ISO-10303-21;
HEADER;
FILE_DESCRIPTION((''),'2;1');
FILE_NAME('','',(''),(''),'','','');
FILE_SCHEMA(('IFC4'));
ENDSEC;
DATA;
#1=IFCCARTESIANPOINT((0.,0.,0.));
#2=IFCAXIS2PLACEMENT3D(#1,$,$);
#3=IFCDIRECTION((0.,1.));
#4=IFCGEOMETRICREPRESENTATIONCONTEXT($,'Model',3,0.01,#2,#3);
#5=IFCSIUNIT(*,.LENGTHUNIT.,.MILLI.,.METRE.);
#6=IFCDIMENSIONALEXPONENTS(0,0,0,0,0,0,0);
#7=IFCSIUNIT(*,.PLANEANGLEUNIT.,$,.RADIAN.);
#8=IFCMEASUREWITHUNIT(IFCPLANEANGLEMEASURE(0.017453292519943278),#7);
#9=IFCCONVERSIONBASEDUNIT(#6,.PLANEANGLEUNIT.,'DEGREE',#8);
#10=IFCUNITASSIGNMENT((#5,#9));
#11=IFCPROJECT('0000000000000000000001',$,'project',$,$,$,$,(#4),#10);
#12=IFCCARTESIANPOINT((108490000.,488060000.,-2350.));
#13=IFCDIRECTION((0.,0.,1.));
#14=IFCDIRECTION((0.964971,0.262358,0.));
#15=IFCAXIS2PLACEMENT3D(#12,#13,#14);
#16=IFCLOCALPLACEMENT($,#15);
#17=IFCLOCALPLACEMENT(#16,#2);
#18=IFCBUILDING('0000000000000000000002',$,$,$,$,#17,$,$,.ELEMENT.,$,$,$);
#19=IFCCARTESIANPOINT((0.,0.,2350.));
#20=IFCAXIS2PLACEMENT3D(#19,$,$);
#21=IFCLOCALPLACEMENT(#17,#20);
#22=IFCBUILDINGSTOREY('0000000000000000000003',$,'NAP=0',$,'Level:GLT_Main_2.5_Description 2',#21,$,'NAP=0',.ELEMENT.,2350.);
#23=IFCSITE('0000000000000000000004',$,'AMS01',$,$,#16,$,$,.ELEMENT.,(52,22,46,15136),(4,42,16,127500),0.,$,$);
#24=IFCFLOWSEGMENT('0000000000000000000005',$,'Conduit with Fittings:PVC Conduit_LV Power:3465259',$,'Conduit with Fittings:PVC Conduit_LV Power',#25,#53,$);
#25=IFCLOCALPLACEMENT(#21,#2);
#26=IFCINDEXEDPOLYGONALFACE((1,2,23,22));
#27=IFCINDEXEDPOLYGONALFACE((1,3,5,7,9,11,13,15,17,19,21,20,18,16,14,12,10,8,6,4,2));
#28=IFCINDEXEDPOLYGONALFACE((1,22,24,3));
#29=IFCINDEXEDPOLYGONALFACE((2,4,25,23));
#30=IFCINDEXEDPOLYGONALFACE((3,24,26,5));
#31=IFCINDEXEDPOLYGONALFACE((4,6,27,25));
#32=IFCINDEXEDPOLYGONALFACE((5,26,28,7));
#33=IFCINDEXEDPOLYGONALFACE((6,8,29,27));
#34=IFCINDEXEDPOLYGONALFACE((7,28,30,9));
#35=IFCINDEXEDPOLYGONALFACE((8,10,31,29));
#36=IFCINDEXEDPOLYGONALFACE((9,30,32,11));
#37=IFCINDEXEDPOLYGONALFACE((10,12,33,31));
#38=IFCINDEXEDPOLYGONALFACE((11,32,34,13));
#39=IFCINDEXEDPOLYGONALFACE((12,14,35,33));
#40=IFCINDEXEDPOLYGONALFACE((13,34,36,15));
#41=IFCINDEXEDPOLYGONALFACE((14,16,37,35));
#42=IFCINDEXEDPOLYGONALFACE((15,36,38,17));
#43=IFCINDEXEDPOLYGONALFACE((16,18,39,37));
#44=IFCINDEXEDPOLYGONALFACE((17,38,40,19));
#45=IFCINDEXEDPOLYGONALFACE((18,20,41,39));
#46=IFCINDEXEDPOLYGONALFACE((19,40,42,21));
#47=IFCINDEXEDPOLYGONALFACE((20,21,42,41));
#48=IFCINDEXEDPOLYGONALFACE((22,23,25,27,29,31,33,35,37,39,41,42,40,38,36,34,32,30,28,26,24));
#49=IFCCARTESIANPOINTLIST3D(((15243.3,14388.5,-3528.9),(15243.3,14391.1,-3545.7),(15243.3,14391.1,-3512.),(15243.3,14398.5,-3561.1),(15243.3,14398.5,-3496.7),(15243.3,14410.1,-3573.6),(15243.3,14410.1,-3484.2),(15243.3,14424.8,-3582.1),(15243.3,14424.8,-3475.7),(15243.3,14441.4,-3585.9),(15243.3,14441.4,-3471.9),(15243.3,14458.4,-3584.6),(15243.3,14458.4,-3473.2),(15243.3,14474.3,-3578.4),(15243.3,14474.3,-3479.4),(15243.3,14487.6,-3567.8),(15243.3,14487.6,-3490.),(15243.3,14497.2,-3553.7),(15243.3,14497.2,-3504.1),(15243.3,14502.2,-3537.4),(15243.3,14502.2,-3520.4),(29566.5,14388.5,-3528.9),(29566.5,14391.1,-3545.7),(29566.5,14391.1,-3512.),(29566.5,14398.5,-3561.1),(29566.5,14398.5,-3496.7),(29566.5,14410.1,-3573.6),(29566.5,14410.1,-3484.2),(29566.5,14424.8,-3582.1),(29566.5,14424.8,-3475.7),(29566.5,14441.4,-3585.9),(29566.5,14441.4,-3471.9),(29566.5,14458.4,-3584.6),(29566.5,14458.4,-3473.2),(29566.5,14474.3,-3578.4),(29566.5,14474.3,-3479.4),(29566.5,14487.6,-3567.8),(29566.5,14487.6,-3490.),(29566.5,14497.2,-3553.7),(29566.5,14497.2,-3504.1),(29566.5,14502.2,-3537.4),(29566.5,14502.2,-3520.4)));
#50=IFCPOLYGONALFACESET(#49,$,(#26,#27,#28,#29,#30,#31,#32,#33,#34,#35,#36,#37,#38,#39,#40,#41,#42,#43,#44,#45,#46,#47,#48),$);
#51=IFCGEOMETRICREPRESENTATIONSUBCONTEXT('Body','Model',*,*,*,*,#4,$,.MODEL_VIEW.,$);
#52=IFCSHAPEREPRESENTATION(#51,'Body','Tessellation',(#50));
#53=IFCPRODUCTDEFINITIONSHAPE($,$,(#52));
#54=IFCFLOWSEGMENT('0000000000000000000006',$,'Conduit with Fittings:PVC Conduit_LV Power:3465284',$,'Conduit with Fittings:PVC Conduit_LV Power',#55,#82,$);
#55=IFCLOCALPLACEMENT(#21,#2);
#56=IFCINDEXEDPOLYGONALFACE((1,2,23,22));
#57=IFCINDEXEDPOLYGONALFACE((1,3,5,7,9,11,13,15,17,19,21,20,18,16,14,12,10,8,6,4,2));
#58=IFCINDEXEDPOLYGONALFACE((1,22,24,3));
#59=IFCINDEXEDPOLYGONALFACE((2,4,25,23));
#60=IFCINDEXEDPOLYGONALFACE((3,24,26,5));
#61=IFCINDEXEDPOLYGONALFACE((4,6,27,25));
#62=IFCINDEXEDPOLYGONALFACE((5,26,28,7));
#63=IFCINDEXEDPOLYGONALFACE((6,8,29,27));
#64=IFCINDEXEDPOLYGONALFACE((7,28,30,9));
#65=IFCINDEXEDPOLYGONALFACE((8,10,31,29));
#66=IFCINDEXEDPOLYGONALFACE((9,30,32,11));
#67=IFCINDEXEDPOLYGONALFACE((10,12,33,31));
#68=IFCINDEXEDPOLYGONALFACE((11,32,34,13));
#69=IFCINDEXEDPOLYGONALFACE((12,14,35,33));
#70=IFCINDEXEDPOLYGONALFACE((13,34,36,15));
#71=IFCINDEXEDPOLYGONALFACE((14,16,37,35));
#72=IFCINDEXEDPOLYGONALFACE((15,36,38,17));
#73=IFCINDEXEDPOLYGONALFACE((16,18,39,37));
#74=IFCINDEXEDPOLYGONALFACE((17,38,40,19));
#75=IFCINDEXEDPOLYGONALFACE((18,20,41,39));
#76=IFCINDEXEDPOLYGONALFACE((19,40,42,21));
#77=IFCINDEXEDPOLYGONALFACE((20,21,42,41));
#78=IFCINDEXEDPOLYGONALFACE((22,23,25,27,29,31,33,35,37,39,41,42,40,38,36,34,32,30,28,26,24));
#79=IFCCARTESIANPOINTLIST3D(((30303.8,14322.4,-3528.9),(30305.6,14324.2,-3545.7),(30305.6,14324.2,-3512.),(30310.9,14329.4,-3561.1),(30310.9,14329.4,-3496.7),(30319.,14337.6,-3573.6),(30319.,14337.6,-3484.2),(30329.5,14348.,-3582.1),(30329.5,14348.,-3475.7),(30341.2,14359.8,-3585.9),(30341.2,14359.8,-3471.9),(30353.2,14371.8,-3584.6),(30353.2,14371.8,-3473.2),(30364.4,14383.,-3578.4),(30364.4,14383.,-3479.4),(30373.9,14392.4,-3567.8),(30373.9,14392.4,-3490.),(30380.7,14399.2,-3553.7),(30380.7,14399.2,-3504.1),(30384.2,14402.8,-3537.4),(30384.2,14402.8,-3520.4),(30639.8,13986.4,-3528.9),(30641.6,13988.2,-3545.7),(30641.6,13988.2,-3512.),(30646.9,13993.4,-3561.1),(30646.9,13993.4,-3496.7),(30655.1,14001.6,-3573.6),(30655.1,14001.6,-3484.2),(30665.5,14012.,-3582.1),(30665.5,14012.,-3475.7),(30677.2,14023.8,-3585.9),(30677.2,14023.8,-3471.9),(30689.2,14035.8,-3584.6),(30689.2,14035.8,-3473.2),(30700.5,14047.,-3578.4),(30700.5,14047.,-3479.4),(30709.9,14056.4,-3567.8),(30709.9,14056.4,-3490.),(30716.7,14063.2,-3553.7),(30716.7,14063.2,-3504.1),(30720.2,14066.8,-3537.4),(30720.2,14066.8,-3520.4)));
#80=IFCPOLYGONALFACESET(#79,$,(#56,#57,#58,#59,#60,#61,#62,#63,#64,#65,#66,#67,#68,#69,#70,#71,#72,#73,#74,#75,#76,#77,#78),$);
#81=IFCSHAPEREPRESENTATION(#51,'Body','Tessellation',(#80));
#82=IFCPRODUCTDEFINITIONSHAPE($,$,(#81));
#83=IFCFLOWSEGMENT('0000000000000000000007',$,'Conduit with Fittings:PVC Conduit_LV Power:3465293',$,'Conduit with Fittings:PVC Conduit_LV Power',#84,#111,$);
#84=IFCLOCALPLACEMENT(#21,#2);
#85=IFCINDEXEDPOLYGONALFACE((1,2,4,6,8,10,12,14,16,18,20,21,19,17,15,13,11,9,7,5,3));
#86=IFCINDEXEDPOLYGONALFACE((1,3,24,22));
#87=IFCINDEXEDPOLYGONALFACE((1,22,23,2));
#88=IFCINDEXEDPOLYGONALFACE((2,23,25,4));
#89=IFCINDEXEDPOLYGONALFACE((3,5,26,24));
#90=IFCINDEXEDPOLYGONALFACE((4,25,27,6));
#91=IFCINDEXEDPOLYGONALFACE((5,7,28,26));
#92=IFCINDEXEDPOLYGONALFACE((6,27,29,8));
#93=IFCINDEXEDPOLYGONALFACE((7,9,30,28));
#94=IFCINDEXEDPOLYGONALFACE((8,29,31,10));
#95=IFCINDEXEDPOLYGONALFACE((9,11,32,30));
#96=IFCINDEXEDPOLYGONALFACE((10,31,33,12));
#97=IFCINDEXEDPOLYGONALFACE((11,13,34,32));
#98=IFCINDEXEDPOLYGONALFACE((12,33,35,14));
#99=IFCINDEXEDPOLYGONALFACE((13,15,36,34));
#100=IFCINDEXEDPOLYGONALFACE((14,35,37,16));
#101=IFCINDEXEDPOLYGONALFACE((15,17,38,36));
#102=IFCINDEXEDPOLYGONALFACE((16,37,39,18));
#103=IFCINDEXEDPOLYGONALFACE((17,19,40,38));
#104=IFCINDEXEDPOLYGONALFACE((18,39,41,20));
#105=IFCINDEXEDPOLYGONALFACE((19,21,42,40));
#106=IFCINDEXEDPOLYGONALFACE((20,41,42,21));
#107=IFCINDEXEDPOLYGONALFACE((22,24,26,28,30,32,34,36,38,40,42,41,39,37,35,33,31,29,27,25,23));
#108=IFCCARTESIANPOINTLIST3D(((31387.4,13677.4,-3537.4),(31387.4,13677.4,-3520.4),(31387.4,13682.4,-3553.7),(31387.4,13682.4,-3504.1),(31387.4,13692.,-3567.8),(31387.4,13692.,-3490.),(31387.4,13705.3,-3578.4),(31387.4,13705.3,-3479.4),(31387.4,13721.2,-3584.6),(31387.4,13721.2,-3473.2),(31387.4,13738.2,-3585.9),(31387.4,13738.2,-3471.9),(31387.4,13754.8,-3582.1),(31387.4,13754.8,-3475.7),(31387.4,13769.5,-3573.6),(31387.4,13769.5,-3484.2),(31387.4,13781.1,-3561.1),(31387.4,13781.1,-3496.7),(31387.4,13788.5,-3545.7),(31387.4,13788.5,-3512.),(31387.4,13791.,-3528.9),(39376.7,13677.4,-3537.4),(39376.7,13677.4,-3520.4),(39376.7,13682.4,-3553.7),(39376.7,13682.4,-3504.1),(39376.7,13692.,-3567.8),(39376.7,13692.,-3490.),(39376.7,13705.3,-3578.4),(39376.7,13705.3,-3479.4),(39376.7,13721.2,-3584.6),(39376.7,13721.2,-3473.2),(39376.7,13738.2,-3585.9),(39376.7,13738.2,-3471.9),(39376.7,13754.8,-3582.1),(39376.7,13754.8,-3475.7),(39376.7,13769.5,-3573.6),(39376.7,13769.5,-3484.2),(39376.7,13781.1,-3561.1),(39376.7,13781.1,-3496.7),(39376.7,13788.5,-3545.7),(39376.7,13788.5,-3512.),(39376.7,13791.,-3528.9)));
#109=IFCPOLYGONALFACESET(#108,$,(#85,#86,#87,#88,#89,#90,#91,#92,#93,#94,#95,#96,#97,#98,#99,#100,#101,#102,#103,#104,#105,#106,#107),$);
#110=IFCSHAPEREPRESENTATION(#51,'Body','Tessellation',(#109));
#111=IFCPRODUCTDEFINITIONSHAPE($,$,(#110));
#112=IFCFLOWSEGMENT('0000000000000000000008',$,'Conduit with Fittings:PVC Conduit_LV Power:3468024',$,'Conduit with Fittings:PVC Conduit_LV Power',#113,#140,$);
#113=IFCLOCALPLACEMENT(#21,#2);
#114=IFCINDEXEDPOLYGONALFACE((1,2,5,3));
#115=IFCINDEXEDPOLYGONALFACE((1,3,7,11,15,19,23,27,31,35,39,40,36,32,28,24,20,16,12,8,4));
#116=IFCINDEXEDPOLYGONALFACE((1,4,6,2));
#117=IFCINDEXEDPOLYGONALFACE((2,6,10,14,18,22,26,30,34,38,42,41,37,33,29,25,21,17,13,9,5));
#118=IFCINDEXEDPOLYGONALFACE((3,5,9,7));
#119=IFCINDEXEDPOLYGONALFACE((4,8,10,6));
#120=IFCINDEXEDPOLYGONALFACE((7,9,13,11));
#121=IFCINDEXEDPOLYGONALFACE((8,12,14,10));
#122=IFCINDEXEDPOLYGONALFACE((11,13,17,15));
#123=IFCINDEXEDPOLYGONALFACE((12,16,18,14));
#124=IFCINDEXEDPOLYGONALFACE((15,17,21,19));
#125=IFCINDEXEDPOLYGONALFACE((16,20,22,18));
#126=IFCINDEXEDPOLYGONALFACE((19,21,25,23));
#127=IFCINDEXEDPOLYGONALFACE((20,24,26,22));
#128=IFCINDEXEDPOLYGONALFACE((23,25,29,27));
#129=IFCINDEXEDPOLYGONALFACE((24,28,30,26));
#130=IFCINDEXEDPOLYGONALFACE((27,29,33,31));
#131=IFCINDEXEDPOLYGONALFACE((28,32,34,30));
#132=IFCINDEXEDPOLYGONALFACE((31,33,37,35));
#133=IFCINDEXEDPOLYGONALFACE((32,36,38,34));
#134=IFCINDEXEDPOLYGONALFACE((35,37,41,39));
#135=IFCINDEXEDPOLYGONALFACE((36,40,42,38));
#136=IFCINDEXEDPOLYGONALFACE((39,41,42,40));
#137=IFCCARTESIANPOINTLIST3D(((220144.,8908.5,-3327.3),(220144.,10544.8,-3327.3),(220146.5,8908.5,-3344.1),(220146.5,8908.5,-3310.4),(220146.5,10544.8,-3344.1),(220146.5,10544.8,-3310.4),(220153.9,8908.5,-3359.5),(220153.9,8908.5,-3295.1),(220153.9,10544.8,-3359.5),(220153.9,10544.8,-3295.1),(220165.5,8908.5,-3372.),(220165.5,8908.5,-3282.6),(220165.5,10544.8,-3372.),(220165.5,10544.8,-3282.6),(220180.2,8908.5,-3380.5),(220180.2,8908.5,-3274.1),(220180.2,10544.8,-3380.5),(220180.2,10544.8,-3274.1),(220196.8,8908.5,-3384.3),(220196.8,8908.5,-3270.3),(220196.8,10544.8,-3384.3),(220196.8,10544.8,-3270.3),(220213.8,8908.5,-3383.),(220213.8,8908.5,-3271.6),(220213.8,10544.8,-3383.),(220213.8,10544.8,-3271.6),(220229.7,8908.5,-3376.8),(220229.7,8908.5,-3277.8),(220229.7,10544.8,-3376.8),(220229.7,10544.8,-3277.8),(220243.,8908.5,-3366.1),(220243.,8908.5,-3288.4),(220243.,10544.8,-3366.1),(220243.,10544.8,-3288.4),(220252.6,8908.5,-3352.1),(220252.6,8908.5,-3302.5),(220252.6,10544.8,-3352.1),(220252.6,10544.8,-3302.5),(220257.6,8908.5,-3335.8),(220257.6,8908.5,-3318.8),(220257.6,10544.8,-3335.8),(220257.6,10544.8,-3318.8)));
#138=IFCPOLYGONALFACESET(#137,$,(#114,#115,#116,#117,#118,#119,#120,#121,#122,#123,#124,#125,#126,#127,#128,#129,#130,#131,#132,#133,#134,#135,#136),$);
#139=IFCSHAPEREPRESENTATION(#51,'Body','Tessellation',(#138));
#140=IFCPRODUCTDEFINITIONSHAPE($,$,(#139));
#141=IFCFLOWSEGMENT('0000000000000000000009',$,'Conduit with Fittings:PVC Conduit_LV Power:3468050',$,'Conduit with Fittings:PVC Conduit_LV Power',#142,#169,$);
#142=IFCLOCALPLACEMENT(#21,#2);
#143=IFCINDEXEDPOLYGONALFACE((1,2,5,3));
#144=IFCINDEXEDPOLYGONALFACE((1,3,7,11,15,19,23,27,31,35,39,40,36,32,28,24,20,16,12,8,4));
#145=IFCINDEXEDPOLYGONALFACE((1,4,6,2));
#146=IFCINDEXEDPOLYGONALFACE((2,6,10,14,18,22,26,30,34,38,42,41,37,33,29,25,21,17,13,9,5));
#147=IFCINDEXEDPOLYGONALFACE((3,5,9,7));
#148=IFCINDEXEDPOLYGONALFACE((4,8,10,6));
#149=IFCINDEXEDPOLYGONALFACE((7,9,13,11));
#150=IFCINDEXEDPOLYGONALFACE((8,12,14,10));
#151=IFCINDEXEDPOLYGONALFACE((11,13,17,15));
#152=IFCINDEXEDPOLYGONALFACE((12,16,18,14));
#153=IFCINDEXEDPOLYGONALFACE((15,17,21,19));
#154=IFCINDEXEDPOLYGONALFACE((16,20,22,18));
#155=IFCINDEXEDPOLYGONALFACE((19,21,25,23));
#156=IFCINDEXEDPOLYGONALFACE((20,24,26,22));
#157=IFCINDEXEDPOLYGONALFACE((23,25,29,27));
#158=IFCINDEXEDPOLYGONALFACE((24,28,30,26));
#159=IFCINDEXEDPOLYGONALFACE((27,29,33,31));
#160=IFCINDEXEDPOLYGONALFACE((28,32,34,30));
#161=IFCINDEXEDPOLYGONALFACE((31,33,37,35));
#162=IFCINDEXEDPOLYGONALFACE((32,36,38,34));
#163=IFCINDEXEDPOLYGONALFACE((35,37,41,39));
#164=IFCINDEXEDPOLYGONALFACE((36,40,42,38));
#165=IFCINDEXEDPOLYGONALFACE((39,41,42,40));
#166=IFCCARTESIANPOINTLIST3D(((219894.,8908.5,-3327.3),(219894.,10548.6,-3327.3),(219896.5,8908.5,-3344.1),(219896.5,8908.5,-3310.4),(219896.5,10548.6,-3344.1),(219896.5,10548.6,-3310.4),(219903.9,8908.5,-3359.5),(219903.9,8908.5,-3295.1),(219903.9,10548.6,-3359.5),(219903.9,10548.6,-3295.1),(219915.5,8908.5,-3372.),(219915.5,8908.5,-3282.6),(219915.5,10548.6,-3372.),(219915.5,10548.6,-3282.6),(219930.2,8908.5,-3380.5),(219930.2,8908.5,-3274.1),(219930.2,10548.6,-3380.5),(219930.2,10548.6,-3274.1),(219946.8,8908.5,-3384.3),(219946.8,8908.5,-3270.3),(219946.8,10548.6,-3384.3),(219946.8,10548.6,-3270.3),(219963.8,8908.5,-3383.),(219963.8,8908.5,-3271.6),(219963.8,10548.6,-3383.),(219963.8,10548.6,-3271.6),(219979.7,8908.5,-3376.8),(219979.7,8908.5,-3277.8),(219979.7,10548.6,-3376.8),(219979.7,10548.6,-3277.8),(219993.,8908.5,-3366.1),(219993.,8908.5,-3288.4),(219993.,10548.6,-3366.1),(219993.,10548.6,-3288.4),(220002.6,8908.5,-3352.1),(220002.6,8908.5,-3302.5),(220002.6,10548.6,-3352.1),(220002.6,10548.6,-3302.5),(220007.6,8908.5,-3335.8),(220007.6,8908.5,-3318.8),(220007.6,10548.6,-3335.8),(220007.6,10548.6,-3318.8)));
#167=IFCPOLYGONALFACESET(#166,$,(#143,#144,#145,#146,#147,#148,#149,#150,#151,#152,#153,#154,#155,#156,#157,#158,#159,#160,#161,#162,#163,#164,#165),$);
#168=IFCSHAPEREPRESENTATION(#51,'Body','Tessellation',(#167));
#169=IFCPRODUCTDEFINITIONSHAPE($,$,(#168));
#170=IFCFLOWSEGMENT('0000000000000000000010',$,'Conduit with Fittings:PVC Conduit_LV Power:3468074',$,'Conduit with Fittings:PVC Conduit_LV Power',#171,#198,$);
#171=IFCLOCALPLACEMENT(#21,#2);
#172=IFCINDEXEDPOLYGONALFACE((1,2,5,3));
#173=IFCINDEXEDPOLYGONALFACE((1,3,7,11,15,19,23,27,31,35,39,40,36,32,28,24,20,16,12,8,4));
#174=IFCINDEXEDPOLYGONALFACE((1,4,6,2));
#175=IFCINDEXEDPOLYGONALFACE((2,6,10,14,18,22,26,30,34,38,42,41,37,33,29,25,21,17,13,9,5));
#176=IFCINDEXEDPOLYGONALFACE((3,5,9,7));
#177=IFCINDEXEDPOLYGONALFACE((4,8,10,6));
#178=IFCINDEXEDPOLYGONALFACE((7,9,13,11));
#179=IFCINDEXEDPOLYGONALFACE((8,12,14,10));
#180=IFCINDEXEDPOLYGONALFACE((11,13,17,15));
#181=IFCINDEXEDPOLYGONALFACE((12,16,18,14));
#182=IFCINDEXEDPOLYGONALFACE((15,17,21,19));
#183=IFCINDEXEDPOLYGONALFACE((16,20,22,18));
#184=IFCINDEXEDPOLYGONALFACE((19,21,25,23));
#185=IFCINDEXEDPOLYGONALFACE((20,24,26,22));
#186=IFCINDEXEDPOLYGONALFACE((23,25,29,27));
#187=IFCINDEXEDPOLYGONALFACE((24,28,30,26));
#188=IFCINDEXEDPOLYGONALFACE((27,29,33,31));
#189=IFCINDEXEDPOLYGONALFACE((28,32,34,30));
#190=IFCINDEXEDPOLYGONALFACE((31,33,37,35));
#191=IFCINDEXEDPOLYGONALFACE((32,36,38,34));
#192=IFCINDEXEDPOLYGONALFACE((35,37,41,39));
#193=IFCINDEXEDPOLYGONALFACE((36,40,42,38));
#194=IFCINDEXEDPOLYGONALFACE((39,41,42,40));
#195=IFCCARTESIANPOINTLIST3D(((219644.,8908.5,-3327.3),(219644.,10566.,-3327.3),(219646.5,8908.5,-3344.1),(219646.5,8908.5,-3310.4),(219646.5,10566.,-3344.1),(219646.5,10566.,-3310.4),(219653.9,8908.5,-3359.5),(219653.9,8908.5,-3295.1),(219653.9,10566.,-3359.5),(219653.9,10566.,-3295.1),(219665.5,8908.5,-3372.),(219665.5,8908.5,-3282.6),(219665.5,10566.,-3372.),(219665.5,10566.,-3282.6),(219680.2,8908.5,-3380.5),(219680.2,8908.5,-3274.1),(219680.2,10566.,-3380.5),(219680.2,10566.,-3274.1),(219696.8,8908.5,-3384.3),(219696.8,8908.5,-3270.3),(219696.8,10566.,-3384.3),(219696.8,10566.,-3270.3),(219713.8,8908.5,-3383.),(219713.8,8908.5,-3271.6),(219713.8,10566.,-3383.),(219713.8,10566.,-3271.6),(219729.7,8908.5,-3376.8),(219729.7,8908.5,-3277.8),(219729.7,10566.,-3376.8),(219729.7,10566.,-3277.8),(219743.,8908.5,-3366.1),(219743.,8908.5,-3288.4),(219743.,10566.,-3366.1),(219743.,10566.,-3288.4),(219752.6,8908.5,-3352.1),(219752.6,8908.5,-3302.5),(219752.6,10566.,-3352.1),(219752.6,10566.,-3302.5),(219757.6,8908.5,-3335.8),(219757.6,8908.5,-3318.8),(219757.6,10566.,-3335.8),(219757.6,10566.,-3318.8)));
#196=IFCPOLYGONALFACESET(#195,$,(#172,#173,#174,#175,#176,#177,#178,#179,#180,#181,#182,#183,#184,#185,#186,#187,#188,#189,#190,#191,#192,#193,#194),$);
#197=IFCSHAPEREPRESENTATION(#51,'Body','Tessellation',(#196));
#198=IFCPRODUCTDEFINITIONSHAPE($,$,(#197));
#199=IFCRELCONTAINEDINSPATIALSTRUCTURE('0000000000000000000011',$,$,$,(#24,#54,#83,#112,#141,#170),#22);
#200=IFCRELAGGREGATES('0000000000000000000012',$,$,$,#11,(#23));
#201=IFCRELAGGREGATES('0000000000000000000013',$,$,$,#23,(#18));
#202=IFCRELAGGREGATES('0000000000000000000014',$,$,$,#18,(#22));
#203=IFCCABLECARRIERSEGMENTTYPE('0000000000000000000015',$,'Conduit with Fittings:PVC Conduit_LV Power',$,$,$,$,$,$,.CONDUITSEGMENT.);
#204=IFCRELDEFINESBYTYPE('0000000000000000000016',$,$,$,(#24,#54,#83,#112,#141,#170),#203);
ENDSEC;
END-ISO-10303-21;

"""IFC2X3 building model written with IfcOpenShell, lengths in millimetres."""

from ifc_helpers import new_model, entity, si_unit, converted_unit, direction, frame, frame_2d, origin, origin_2d_with_axis, place, context, subcontext, project, spatial, circle, extrude, type_object, element, save


model = new_model("IFC2X3")

# Units and contexts
model_context = context("Model", 3, precision=0.01, world=origin(), true_north=direction((0.0, 1.0)))
body_context = subcontext(model_context, "Body", "Model", "MODEL_VIEW")
ifc_project = project(units=[si_unit("LENGTHUNIT", "METRE", prefix="MILLI"), converted_unit("PLANEANGLEUNIT", "DEGREE", entity("IfcPlaneAngleMeasure", 0.017453292519943278), si_unit("PLANEANGLEUNIT", "RADIAN"), dimensions=[0, 0, 0, 0, 0, 0, 0])], contexts=[model_context])

# Site, building, storey
site_placement = place(None, frame((108490000.0, 488060000.0, -2350.0), z_axis=(0.0, 0.0, 1.0), x_axis=(0.964971, 0.262358, 0.0)))
site = spatial("IfcSite", under=ifc_project, at=site_placement, Name="AMS01", CompositionType="ELEMENT", RefLatitude=(52, 22, 46, 15136), RefLongitude=(4, 42, 16, 127500), RefElevation=0.0)
building_placement = place(site_placement, origin())
building = spatial("IfcBuilding", under=site, at=building_placement, CompositionType="ELEMENT")
storey_placement = place(building_placement, frame((0.0, 0.0, 2350.0)))
storey = spatial("IfcBuildingStorey", under=building, at=storey_placement, Name="NAP=0", ObjectType="Level:GLT_Main_2.5_Description 2", LongName="NAP=0", CompositionType="ELEMENT", Elevation=2350.0)

# Flow segments
cable_carrier_segment_type = type_object("IfcCableCarrierSegmentType", Name="Conduit with Fittings:PVC Conduit_LV Power", PredefinedType="CONDUITSEGMENT")
flow_segment_1_placement = place(storey_placement, origin())
element("IfcFlowSegment", 1, at=flow_segment_1_placement, inside=storey, type_object=cable_carrier_segment_type, Name="Conduit with Fittings:PVC Conduit_LV Power:3465259", ObjectType="Conduit with Fittings:PVC Conduit_LV Power", context=body_context, shape_type="SweptSolid", body=[
    extrude(circle(Radius=57.2, at=frame_2d((0.0, 0.0), x_axis=(1.0, 0.0))), frame((15243.3, 14445.7, -3528.9), z_axis=(1.0, 0.0, 0.0), x_axis=(0.0, -1.0, 0.0)), (0.0, 0.0, 1.0), 14323.1),
])
flow_segment_2_placement = place(storey_placement, origin())
element("IfcFlowSegment", 2, at=flow_segment_2_placement, inside=storey, type_object=cable_carrier_segment_type, Name="Conduit with Fittings:PVC Conduit_LV Power:3465284", ObjectType="Conduit with Fittings:PVC Conduit_LV Power", context=body_context, shape_type="SweptSolid", body=[
    extrude(circle(Radius=57.2, at=origin_2d_with_axis()), frame((30680.3, 14026.8, -3528.9), z_axis=(-0.707107, 0.707107, 0.0), x_axis=(-0.707107, -0.707107, 0.0)), (0.0, 0.0, 1.0), 475.2),
])
flow_segment_3_placement = place(storey_placement, origin())
element("IfcFlowSegment", 3, at=flow_segment_3_placement, inside=storey, type_object=cable_carrier_segment_type, Name="Conduit with Fittings:PVC Conduit_LV Power:3465293", ObjectType="Conduit with Fittings:PVC Conduit_LV Power", context=body_context, shape_type="SweptSolid", body=[
    extrude(circle(Radius=57.2, at=frame_2d((0.0, 0.0), x_axis=(1.0, 0.0))), frame((31387.4, 13733.9, -3528.9), z_axis=(1.0, 0.0, 0.0), x_axis=(0.0, 1.0, 0.0)), (0.0, 0.0, 1.0), 7989.3),
])
flow_segment_4_placement = place(storey_placement, origin())
element("IfcFlowSegment", 4, at=flow_segment_4_placement, inside=storey, type_object=cable_carrier_segment_type, Name="Conduit with Fittings:PVC Conduit_LV Power:3468024", ObjectType="Conduit with Fittings:PVC Conduit_LV Power", context=body_context, shape_type="SweptSolid", body=[
    extrude(circle(Radius=57.2, at=frame_2d((0.0, 0.0), x_axis=(1.0, 0.0))), frame((220201.1, 8908.5, -3327.3), z_axis=(0.0, 1.0, 0.0), x_axis=(-1.0, 0.0, 0.0)), (0.0, 0.0, 1.0), 1636.3),
])
flow_segment_5_placement = place(storey_placement, origin())
element("IfcFlowSegment", 5, at=flow_segment_5_placement, inside=storey, type_object=cable_carrier_segment_type, Name="Conduit with Fittings:PVC Conduit_LV Power:3468050", ObjectType="Conduit with Fittings:PVC Conduit_LV Power", context=body_context, shape_type="SweptSolid", body=[
    extrude(circle(Radius=57.2, at=frame_2d((0.0, 0.0), x_axis=(1.0, 0.0))), frame((219951.1, 8908.5, -3327.3), z_axis=(0.0, 1.0, 0.0), x_axis=(-1.0, 0.0, 0.0)), (0.0, 0.0, 1.0), 1640.2),
])
flow_segment_6_placement = place(storey_placement, origin())
element("IfcFlowSegment", 6, at=flow_segment_6_placement, inside=storey, type_object=cable_carrier_segment_type, Name="Conduit with Fittings:PVC Conduit_LV Power:3468074", ObjectType="Conduit with Fittings:PVC Conduit_LV Power", context=body_context, shape_type="SweptSolid", body=[
    extrude(circle(Radius=57.2, at=frame_2d((0.0, 0.0), x_axis=(1.0, 0.0))), frame((219701.1, 8908.5, -3327.3), z_axis=(0.0, 1.0, 0.0), x_axis=(-1.0, 0.0, 0.0)), (0.0, 0.0, 1.0), 1657.5),
])

save(model, "model.ifc")
